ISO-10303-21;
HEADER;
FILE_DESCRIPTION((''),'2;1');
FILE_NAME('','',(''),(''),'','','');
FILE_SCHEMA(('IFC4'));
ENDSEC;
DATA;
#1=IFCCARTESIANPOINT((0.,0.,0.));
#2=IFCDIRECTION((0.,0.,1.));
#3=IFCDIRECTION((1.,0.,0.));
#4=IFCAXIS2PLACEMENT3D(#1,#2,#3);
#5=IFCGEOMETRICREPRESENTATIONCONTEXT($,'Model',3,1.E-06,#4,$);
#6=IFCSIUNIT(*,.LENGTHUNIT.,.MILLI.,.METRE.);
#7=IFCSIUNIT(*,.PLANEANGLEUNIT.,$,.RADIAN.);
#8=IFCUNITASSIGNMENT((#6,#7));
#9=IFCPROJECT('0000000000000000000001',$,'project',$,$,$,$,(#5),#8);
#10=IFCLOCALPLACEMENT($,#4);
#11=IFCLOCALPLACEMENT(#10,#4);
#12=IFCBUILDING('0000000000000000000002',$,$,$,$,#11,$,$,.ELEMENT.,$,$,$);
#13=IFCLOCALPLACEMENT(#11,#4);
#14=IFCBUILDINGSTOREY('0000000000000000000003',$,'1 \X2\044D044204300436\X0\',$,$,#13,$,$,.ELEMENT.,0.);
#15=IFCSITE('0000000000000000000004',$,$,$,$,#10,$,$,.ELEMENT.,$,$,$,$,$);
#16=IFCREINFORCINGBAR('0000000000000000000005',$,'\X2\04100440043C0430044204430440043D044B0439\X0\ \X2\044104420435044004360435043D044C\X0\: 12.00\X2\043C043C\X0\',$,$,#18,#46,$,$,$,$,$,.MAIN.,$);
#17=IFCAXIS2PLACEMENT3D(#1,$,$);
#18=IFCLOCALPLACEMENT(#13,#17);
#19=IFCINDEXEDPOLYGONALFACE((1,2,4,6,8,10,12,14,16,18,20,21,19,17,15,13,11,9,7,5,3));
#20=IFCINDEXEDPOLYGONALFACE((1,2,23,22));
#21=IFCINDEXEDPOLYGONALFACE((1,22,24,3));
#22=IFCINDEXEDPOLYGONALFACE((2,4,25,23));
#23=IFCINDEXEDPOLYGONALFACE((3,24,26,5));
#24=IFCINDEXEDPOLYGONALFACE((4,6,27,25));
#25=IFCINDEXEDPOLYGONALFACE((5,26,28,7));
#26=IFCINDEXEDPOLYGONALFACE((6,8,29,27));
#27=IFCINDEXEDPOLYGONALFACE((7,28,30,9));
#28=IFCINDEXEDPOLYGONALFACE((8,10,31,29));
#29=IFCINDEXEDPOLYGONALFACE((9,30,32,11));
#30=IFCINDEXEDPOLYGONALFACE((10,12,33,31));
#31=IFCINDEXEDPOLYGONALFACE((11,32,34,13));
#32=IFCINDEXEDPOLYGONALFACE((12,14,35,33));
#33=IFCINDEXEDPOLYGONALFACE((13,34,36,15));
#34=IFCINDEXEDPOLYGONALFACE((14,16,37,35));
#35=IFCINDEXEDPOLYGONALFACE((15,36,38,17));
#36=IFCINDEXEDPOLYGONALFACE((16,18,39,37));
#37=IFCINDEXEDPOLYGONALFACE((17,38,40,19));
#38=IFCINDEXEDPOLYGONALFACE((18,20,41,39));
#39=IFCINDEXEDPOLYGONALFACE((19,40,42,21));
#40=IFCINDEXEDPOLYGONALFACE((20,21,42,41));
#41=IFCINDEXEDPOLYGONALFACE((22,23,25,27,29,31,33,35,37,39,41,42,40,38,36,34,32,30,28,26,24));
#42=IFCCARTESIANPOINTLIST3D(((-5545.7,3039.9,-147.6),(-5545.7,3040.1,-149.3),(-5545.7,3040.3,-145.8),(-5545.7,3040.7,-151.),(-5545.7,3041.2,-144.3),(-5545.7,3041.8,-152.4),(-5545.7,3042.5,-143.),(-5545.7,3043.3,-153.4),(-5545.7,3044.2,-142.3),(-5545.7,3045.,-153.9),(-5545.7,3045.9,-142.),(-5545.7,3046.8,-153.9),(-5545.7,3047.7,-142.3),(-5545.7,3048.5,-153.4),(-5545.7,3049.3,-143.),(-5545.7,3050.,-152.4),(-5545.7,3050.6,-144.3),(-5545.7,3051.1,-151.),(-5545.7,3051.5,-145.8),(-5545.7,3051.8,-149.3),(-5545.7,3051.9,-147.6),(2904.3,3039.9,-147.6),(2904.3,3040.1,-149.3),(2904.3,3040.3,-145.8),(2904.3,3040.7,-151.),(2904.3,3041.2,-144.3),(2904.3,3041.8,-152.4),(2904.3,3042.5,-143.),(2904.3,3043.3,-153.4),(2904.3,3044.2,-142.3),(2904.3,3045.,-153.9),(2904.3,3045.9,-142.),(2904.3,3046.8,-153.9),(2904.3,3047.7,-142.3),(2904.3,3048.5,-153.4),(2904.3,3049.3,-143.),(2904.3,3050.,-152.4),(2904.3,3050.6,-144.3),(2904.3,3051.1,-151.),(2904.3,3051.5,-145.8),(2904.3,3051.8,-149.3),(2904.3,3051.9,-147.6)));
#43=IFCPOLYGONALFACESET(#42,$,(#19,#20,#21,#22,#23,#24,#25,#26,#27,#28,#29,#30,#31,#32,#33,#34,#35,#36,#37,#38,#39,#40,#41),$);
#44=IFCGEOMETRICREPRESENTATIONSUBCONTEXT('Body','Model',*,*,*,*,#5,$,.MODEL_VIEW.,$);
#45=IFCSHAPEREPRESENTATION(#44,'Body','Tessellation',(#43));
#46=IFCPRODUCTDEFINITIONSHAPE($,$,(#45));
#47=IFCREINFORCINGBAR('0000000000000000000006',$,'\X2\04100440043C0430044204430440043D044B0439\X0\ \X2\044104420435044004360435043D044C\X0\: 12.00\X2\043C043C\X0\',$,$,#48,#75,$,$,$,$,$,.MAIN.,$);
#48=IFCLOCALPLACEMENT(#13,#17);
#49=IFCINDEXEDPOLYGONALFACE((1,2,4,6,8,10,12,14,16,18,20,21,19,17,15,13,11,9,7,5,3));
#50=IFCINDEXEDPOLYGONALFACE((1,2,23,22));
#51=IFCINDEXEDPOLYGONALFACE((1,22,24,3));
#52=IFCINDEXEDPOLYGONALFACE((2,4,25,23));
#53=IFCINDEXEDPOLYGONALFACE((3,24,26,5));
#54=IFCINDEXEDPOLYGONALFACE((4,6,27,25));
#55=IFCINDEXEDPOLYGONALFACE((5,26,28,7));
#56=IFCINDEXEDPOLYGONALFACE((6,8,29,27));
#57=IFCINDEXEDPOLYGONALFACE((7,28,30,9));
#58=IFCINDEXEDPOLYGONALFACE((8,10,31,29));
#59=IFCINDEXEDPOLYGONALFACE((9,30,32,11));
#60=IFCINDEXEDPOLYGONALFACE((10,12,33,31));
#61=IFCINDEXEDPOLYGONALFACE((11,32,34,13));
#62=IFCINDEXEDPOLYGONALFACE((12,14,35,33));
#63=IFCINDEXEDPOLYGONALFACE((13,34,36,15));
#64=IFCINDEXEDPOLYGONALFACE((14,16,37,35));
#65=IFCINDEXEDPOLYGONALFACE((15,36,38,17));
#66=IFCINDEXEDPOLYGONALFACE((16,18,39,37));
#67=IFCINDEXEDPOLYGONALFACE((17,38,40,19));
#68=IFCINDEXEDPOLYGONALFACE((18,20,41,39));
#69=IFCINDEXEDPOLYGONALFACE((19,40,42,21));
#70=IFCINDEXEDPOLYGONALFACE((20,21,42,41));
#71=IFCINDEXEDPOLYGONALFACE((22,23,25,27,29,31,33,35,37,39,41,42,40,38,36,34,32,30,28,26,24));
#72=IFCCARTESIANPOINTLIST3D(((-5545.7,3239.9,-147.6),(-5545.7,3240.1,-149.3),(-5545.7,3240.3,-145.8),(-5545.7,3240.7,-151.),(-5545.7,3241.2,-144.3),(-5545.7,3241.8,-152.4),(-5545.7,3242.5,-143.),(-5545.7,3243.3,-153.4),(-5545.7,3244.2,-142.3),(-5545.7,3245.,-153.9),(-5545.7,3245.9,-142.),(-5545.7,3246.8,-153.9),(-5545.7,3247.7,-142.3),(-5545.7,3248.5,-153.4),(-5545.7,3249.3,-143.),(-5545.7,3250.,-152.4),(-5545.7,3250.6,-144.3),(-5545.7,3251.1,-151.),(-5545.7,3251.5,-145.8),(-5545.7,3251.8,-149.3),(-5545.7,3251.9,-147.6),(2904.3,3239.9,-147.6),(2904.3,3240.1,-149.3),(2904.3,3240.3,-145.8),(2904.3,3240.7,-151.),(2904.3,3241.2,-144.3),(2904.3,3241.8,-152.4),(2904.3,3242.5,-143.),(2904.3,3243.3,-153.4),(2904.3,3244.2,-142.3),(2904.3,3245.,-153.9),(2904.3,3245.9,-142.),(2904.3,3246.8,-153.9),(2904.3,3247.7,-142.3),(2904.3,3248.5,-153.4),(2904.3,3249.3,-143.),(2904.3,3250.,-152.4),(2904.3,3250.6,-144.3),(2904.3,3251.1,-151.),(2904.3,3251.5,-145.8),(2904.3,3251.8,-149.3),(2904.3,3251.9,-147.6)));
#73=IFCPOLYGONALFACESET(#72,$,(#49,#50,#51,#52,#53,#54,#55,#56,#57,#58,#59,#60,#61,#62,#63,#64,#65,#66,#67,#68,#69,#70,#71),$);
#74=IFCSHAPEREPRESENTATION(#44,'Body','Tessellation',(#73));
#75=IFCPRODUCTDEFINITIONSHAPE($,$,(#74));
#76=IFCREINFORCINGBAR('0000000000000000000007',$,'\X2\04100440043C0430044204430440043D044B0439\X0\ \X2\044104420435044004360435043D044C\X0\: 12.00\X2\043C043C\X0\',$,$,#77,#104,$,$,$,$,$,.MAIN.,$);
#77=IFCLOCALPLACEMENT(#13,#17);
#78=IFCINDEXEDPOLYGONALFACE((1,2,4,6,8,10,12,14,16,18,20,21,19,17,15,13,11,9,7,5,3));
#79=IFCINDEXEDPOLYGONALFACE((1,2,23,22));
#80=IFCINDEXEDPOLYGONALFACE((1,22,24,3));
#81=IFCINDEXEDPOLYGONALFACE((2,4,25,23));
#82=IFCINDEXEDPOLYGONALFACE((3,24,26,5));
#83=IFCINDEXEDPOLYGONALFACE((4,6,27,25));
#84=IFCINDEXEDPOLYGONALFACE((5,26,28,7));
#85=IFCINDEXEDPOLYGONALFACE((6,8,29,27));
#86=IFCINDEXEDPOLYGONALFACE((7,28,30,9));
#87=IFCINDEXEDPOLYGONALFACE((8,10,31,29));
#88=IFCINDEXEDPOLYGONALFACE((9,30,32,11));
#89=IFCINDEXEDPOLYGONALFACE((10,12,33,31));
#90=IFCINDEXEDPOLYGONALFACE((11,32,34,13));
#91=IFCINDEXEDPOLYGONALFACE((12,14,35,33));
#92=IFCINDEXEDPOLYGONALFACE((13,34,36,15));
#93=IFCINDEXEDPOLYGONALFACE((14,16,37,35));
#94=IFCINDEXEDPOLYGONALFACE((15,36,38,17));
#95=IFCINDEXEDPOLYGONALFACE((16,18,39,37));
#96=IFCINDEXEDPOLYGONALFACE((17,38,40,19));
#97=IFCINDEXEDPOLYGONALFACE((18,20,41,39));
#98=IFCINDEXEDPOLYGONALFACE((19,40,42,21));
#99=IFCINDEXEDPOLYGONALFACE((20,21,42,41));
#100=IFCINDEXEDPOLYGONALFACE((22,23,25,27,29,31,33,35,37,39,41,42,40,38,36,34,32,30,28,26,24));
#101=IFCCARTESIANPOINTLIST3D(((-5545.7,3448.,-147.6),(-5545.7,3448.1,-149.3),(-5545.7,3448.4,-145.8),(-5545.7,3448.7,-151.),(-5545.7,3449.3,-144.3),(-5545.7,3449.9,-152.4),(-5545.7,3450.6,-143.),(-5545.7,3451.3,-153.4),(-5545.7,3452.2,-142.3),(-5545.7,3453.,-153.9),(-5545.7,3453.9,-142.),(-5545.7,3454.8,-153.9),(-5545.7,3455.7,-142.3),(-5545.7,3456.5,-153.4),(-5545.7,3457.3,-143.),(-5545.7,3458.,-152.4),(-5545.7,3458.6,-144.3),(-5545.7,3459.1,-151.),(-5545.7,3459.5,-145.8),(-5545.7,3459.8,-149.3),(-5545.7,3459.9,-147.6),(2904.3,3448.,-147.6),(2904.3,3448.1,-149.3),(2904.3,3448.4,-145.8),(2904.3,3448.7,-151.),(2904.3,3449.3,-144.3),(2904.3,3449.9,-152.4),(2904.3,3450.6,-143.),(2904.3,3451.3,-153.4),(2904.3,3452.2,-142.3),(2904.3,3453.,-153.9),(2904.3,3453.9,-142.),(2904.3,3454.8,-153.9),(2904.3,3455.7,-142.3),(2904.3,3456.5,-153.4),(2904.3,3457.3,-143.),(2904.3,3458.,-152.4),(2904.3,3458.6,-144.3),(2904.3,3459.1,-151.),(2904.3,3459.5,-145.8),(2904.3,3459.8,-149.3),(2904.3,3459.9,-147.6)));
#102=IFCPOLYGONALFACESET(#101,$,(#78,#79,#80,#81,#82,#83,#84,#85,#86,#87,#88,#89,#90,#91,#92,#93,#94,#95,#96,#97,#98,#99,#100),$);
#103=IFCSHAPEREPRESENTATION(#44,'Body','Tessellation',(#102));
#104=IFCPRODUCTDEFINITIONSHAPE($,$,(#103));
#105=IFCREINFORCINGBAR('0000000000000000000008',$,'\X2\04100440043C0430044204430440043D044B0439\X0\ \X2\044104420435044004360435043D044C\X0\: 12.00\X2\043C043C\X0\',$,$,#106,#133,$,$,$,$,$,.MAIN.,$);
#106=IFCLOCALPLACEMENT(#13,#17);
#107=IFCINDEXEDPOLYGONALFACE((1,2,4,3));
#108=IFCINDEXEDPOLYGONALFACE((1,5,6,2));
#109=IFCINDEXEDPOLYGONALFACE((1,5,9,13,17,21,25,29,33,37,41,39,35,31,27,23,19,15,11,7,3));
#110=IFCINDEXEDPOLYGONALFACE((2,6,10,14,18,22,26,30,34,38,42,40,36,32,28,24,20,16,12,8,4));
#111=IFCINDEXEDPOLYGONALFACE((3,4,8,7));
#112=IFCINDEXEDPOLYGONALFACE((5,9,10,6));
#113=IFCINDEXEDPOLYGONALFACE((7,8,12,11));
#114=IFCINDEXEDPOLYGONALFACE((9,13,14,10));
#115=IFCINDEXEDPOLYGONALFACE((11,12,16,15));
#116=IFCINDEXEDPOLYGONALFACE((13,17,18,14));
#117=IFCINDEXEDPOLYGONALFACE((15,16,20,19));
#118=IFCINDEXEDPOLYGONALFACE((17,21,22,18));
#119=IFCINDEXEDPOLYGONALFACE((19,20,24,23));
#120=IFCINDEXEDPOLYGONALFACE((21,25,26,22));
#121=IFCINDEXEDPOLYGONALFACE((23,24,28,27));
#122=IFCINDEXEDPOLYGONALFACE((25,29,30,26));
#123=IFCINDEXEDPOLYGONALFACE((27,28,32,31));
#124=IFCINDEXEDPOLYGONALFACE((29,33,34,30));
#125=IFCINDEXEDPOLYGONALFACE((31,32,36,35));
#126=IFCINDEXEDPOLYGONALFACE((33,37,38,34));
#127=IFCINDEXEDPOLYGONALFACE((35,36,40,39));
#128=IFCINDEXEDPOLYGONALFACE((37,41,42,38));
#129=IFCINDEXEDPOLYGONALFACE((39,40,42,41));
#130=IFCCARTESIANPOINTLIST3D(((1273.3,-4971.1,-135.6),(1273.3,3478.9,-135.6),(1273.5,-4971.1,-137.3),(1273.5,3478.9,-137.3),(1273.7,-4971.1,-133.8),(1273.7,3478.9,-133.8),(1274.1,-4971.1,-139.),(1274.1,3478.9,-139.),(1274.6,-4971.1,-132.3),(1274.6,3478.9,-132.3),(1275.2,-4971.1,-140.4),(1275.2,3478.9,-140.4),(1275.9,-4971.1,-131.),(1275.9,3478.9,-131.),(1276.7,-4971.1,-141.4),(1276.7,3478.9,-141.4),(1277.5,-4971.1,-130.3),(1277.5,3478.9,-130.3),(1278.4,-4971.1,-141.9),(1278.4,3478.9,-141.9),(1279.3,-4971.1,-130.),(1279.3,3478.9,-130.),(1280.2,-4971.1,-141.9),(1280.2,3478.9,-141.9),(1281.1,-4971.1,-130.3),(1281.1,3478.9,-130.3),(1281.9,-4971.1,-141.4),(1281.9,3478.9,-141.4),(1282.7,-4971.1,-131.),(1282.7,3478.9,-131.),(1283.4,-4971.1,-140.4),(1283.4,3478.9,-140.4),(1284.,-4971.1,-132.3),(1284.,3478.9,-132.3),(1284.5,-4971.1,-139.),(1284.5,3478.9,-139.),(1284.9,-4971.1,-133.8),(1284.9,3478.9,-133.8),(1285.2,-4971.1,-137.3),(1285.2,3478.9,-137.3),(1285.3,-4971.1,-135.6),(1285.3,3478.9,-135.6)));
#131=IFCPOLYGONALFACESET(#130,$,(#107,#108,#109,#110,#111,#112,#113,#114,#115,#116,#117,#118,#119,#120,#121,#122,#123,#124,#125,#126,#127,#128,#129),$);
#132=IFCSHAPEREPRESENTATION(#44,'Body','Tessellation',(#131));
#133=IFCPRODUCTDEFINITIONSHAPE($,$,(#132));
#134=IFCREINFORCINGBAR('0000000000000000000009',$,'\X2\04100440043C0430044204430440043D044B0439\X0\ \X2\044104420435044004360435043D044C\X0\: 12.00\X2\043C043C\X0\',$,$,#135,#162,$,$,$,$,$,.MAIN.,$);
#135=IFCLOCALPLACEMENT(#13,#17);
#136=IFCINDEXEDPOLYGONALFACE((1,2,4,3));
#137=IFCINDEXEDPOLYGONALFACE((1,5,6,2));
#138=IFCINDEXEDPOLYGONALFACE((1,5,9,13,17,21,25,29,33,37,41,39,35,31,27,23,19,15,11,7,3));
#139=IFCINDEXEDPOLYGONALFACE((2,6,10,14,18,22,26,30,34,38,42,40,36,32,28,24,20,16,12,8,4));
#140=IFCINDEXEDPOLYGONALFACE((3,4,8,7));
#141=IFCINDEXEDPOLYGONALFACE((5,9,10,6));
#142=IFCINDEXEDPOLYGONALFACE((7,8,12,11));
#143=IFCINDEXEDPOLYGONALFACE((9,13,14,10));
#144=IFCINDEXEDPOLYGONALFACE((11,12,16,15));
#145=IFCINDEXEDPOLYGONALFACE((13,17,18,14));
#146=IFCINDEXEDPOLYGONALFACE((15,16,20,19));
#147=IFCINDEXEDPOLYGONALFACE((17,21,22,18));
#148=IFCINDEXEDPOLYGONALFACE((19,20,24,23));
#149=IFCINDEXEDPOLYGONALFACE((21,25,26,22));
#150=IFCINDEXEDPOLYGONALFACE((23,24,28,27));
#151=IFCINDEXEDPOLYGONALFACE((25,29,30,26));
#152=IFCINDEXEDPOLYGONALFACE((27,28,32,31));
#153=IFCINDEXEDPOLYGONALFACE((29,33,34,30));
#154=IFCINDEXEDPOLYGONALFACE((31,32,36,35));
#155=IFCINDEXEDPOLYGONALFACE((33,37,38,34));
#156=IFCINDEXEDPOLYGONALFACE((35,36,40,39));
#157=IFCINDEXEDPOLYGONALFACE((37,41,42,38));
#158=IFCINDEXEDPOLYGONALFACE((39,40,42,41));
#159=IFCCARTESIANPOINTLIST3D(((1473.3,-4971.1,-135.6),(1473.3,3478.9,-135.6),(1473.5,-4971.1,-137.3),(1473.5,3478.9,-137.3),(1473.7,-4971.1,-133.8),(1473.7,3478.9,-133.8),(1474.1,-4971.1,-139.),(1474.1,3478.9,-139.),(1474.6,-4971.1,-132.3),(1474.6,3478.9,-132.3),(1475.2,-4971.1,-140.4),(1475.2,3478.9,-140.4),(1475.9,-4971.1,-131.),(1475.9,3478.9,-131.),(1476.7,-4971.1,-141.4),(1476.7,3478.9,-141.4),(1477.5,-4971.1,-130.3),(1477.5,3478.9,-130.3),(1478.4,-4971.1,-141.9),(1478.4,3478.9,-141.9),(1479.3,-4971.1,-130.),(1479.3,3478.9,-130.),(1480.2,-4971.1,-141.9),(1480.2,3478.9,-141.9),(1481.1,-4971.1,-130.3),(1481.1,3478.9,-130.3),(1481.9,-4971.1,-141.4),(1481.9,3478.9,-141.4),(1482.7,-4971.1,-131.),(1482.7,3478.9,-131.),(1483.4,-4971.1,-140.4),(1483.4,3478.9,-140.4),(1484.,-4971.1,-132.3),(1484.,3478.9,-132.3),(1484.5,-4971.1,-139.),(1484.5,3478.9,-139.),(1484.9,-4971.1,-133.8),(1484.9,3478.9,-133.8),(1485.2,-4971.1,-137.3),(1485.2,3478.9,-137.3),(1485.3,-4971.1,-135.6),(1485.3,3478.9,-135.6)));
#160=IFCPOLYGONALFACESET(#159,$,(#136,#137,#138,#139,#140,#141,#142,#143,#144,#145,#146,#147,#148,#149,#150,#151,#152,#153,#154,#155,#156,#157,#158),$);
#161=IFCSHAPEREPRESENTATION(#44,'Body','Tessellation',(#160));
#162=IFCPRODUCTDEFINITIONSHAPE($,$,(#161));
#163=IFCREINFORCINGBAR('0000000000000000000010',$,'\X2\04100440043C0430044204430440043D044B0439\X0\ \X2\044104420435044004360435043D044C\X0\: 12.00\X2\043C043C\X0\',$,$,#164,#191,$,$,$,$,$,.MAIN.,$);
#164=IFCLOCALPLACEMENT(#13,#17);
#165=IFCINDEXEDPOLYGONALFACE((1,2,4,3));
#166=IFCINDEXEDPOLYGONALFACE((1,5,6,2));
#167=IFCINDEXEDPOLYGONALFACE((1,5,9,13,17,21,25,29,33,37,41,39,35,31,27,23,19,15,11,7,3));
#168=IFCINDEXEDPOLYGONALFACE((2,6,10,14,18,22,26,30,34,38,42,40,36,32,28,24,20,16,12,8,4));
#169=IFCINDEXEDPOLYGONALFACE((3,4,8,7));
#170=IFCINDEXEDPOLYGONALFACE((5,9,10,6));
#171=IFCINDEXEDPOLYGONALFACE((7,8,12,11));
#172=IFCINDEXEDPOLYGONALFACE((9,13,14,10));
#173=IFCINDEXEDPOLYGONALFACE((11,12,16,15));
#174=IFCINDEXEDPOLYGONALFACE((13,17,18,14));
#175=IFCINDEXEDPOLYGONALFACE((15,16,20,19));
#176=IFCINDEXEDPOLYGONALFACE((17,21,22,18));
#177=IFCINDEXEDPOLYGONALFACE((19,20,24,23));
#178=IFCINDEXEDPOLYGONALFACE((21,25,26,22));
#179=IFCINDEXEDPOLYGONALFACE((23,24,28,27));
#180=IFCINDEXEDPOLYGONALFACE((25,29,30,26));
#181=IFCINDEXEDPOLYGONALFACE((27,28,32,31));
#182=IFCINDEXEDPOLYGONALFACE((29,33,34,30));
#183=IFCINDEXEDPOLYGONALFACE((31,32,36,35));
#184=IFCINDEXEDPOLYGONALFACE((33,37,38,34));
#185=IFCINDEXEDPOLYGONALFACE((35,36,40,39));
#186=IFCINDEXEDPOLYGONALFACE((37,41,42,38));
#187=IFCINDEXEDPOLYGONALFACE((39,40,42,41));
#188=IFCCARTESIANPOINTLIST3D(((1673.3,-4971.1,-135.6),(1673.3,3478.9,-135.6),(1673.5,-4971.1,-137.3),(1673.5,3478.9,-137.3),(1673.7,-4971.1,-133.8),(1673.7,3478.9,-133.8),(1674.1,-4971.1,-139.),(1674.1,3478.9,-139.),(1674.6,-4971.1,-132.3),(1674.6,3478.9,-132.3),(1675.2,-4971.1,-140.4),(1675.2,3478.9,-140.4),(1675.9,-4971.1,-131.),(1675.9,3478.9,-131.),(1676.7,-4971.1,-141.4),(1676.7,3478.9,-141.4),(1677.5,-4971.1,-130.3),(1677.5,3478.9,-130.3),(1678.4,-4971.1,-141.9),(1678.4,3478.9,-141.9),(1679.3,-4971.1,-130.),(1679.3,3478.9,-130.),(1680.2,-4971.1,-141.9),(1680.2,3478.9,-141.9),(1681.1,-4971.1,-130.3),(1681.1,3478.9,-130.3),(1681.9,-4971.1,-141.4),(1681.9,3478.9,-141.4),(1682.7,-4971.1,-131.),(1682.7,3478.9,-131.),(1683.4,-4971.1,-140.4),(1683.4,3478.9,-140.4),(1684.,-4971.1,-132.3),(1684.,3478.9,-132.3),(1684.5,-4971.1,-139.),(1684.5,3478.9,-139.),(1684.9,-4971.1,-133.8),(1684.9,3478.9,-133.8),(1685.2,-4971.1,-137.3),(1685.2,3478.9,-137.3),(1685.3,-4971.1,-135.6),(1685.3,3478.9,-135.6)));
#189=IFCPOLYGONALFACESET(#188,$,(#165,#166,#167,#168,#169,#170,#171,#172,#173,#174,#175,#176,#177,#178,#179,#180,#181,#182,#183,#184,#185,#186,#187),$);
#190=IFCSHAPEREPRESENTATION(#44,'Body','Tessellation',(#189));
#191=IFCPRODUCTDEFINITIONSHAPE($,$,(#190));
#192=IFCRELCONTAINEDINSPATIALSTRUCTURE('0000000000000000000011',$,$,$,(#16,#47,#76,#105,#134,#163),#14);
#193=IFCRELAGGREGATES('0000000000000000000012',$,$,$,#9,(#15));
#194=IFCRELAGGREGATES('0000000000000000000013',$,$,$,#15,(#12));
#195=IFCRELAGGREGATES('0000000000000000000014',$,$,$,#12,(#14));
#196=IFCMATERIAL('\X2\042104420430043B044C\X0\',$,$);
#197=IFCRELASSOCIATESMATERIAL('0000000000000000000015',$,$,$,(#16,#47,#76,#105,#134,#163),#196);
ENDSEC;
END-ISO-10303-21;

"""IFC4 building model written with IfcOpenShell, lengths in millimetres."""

from ifc_helpers import new_model, entity, si_unit, origin_with_axes, place, context, subcontext, project, spatial, source, transform, mapped, material, element, save


model = new_model("IFC4")

# Units and contexts
model_context = context("Model", 3, precision=1e-06, world=origin_with_axes())
body_context = subcontext(model_context, "Body", "Model", "MODEL_VIEW")
ifc_project = project(units=[si_unit("LENGTHUNIT", "METRE", prefix="MILLI"), si_unit("PLANEANGLEUNIT", "RADIAN")], contexts=[model_context])

# Site, building, storey
site_placement = place(None, origin_with_axes())
site = spatial("IfcSite", under=ifc_project, at=site_placement, CompositionType="ELEMENT")
building_placement = place(site_placement, origin_with_axes())
building = spatial("IfcBuilding", under=site, at=building_placement, CompositionType="ELEMENT")
storey_placement = place(building_placement, origin_with_axes())
storey = spatial("IfcBuildingStorey", under=building, at=storey_placement, Name="1 этаж", CompositionType="ELEMENT", Elevation=0.0)

# Reinforcing bars
ifc_material = material(Name="Сталь")
shared_shape = source(origin_with_axes(), body_context, "Body", "AdvancedSweptSolid", [
    entity("IfcSweptDiskSolid", entity("IfcIndexedPolyCurve", entity("IfcCartesianPointList3D", [[0.0, 0.0, 0.0], [8450.0, 0.0, 0.0]]), [entity("IfcLineIndex", [1, 2])]), 6.0),
])
reinforcing_bar_1_placement = place(storey_placement, origin_with_axes())
element("IfcReinforcingBar", 1, at=reinforcing_bar_1_placement, inside=storey, material=ifc_material, Name="Арматурный стержень: 12.00мм", PredefinedType="MAIN", context=body_context, shape_type="MappedRepresentation", body=[
    mapped(shared_shape, transform((-5545.7, 3045.9, -148.0), x_axis=(1.0, 0.0, 0.0), y_axis=(0.0, 1.0, 0.0), z_axis=(0.0, 0.0, 1.0), scale=1.0)),
])
reinforcing_bar_2_placement = place(storey_placement, origin_with_axes())
element("IfcReinforcingBar", 2, at=reinforcing_bar_2_placement, inside=storey, material=ifc_material, Name="Арматурный стержень: 12.00мм", PredefinedType="MAIN", context=body_context, shape_type="MappedRepresentation", body=[
    mapped(shared_shape, transform((-5545.7, 3245.9, -148.0), x_axis=(1.0, 0.0, 0.0), y_axis=(0.0, 1.0, 0.0), z_axis=(0.0, 0.0, 1.0), scale=1.0)),
])
reinforcing_bar_3_placement = place(storey_placement, origin_with_axes())
element("IfcReinforcingBar", 3, at=reinforcing_bar_3_placement, inside=storey, material=ifc_material, Name="Арматурный стержень: 12.00мм", PredefinedType="MAIN", context=body_context, shape_type="MappedRepresentation", body=[
    mapped(shared_shape, transform((-5545.7, 3453.9, -148.0), x_axis=(1.0, 0.0, 0.0), y_axis=(0.0, 1.0, 0.0), z_axis=(0.0, 0.0, 1.0), scale=1.0)),
])
reinforcing_bar_4_placement = place(storey_placement, origin_with_axes())
element("IfcReinforcingBar", 4, at=reinforcing_bar_4_placement, inside=storey, material=ifc_material, Name="Арматурный стержень: 12.00мм", PredefinedType="MAIN", context=body_context, shape_type="MappedRepresentation", body=[
    mapped(shared_shape, transform((1279.3, -4971.1, -136.0), x_axis=(0.0, 1.0, 0.0), y_axis=(-1.0, 0.0, 0.0), z_axis=(0.0, 0.0, 1.0), scale=1.0)),
])
reinforcing_bar_5_placement = place(storey_placement, origin_with_axes())
element("IfcReinforcingBar", 5, at=reinforcing_bar_5_placement, inside=storey, material=ifc_material, Name="Арматурный стержень: 12.00мм", PredefinedType="MAIN", context=body_context, shape_type="MappedRepresentation", body=[
    mapped(shared_shape, transform((1479.3, -4971.1, -136.0), x_axis=(0.0, 1.0, 0.0), y_axis=(-1.0, 0.0, 0.0), z_axis=(0.0, 0.0, 1.0), scale=1.0)),
])
reinforcing_bar_6_placement = place(storey_placement, origin_with_axes())
element("IfcReinforcingBar", 6, at=reinforcing_bar_6_placement, inside=storey, material=ifc_material, Name="Арматурный стержень: 12.00мм", PredefinedType="MAIN", context=body_context, shape_type="MappedRepresentation", body=[
    mapped(shared_shape, transform((1679.3, -4971.1, -136.0), x_axis=(0.0, 1.0, 0.0), y_axis=(-1.0, 0.0, 0.0), z_axis=(0.0, 0.0, 1.0), scale=1.0)),
])

save(model, "model.ifc")
